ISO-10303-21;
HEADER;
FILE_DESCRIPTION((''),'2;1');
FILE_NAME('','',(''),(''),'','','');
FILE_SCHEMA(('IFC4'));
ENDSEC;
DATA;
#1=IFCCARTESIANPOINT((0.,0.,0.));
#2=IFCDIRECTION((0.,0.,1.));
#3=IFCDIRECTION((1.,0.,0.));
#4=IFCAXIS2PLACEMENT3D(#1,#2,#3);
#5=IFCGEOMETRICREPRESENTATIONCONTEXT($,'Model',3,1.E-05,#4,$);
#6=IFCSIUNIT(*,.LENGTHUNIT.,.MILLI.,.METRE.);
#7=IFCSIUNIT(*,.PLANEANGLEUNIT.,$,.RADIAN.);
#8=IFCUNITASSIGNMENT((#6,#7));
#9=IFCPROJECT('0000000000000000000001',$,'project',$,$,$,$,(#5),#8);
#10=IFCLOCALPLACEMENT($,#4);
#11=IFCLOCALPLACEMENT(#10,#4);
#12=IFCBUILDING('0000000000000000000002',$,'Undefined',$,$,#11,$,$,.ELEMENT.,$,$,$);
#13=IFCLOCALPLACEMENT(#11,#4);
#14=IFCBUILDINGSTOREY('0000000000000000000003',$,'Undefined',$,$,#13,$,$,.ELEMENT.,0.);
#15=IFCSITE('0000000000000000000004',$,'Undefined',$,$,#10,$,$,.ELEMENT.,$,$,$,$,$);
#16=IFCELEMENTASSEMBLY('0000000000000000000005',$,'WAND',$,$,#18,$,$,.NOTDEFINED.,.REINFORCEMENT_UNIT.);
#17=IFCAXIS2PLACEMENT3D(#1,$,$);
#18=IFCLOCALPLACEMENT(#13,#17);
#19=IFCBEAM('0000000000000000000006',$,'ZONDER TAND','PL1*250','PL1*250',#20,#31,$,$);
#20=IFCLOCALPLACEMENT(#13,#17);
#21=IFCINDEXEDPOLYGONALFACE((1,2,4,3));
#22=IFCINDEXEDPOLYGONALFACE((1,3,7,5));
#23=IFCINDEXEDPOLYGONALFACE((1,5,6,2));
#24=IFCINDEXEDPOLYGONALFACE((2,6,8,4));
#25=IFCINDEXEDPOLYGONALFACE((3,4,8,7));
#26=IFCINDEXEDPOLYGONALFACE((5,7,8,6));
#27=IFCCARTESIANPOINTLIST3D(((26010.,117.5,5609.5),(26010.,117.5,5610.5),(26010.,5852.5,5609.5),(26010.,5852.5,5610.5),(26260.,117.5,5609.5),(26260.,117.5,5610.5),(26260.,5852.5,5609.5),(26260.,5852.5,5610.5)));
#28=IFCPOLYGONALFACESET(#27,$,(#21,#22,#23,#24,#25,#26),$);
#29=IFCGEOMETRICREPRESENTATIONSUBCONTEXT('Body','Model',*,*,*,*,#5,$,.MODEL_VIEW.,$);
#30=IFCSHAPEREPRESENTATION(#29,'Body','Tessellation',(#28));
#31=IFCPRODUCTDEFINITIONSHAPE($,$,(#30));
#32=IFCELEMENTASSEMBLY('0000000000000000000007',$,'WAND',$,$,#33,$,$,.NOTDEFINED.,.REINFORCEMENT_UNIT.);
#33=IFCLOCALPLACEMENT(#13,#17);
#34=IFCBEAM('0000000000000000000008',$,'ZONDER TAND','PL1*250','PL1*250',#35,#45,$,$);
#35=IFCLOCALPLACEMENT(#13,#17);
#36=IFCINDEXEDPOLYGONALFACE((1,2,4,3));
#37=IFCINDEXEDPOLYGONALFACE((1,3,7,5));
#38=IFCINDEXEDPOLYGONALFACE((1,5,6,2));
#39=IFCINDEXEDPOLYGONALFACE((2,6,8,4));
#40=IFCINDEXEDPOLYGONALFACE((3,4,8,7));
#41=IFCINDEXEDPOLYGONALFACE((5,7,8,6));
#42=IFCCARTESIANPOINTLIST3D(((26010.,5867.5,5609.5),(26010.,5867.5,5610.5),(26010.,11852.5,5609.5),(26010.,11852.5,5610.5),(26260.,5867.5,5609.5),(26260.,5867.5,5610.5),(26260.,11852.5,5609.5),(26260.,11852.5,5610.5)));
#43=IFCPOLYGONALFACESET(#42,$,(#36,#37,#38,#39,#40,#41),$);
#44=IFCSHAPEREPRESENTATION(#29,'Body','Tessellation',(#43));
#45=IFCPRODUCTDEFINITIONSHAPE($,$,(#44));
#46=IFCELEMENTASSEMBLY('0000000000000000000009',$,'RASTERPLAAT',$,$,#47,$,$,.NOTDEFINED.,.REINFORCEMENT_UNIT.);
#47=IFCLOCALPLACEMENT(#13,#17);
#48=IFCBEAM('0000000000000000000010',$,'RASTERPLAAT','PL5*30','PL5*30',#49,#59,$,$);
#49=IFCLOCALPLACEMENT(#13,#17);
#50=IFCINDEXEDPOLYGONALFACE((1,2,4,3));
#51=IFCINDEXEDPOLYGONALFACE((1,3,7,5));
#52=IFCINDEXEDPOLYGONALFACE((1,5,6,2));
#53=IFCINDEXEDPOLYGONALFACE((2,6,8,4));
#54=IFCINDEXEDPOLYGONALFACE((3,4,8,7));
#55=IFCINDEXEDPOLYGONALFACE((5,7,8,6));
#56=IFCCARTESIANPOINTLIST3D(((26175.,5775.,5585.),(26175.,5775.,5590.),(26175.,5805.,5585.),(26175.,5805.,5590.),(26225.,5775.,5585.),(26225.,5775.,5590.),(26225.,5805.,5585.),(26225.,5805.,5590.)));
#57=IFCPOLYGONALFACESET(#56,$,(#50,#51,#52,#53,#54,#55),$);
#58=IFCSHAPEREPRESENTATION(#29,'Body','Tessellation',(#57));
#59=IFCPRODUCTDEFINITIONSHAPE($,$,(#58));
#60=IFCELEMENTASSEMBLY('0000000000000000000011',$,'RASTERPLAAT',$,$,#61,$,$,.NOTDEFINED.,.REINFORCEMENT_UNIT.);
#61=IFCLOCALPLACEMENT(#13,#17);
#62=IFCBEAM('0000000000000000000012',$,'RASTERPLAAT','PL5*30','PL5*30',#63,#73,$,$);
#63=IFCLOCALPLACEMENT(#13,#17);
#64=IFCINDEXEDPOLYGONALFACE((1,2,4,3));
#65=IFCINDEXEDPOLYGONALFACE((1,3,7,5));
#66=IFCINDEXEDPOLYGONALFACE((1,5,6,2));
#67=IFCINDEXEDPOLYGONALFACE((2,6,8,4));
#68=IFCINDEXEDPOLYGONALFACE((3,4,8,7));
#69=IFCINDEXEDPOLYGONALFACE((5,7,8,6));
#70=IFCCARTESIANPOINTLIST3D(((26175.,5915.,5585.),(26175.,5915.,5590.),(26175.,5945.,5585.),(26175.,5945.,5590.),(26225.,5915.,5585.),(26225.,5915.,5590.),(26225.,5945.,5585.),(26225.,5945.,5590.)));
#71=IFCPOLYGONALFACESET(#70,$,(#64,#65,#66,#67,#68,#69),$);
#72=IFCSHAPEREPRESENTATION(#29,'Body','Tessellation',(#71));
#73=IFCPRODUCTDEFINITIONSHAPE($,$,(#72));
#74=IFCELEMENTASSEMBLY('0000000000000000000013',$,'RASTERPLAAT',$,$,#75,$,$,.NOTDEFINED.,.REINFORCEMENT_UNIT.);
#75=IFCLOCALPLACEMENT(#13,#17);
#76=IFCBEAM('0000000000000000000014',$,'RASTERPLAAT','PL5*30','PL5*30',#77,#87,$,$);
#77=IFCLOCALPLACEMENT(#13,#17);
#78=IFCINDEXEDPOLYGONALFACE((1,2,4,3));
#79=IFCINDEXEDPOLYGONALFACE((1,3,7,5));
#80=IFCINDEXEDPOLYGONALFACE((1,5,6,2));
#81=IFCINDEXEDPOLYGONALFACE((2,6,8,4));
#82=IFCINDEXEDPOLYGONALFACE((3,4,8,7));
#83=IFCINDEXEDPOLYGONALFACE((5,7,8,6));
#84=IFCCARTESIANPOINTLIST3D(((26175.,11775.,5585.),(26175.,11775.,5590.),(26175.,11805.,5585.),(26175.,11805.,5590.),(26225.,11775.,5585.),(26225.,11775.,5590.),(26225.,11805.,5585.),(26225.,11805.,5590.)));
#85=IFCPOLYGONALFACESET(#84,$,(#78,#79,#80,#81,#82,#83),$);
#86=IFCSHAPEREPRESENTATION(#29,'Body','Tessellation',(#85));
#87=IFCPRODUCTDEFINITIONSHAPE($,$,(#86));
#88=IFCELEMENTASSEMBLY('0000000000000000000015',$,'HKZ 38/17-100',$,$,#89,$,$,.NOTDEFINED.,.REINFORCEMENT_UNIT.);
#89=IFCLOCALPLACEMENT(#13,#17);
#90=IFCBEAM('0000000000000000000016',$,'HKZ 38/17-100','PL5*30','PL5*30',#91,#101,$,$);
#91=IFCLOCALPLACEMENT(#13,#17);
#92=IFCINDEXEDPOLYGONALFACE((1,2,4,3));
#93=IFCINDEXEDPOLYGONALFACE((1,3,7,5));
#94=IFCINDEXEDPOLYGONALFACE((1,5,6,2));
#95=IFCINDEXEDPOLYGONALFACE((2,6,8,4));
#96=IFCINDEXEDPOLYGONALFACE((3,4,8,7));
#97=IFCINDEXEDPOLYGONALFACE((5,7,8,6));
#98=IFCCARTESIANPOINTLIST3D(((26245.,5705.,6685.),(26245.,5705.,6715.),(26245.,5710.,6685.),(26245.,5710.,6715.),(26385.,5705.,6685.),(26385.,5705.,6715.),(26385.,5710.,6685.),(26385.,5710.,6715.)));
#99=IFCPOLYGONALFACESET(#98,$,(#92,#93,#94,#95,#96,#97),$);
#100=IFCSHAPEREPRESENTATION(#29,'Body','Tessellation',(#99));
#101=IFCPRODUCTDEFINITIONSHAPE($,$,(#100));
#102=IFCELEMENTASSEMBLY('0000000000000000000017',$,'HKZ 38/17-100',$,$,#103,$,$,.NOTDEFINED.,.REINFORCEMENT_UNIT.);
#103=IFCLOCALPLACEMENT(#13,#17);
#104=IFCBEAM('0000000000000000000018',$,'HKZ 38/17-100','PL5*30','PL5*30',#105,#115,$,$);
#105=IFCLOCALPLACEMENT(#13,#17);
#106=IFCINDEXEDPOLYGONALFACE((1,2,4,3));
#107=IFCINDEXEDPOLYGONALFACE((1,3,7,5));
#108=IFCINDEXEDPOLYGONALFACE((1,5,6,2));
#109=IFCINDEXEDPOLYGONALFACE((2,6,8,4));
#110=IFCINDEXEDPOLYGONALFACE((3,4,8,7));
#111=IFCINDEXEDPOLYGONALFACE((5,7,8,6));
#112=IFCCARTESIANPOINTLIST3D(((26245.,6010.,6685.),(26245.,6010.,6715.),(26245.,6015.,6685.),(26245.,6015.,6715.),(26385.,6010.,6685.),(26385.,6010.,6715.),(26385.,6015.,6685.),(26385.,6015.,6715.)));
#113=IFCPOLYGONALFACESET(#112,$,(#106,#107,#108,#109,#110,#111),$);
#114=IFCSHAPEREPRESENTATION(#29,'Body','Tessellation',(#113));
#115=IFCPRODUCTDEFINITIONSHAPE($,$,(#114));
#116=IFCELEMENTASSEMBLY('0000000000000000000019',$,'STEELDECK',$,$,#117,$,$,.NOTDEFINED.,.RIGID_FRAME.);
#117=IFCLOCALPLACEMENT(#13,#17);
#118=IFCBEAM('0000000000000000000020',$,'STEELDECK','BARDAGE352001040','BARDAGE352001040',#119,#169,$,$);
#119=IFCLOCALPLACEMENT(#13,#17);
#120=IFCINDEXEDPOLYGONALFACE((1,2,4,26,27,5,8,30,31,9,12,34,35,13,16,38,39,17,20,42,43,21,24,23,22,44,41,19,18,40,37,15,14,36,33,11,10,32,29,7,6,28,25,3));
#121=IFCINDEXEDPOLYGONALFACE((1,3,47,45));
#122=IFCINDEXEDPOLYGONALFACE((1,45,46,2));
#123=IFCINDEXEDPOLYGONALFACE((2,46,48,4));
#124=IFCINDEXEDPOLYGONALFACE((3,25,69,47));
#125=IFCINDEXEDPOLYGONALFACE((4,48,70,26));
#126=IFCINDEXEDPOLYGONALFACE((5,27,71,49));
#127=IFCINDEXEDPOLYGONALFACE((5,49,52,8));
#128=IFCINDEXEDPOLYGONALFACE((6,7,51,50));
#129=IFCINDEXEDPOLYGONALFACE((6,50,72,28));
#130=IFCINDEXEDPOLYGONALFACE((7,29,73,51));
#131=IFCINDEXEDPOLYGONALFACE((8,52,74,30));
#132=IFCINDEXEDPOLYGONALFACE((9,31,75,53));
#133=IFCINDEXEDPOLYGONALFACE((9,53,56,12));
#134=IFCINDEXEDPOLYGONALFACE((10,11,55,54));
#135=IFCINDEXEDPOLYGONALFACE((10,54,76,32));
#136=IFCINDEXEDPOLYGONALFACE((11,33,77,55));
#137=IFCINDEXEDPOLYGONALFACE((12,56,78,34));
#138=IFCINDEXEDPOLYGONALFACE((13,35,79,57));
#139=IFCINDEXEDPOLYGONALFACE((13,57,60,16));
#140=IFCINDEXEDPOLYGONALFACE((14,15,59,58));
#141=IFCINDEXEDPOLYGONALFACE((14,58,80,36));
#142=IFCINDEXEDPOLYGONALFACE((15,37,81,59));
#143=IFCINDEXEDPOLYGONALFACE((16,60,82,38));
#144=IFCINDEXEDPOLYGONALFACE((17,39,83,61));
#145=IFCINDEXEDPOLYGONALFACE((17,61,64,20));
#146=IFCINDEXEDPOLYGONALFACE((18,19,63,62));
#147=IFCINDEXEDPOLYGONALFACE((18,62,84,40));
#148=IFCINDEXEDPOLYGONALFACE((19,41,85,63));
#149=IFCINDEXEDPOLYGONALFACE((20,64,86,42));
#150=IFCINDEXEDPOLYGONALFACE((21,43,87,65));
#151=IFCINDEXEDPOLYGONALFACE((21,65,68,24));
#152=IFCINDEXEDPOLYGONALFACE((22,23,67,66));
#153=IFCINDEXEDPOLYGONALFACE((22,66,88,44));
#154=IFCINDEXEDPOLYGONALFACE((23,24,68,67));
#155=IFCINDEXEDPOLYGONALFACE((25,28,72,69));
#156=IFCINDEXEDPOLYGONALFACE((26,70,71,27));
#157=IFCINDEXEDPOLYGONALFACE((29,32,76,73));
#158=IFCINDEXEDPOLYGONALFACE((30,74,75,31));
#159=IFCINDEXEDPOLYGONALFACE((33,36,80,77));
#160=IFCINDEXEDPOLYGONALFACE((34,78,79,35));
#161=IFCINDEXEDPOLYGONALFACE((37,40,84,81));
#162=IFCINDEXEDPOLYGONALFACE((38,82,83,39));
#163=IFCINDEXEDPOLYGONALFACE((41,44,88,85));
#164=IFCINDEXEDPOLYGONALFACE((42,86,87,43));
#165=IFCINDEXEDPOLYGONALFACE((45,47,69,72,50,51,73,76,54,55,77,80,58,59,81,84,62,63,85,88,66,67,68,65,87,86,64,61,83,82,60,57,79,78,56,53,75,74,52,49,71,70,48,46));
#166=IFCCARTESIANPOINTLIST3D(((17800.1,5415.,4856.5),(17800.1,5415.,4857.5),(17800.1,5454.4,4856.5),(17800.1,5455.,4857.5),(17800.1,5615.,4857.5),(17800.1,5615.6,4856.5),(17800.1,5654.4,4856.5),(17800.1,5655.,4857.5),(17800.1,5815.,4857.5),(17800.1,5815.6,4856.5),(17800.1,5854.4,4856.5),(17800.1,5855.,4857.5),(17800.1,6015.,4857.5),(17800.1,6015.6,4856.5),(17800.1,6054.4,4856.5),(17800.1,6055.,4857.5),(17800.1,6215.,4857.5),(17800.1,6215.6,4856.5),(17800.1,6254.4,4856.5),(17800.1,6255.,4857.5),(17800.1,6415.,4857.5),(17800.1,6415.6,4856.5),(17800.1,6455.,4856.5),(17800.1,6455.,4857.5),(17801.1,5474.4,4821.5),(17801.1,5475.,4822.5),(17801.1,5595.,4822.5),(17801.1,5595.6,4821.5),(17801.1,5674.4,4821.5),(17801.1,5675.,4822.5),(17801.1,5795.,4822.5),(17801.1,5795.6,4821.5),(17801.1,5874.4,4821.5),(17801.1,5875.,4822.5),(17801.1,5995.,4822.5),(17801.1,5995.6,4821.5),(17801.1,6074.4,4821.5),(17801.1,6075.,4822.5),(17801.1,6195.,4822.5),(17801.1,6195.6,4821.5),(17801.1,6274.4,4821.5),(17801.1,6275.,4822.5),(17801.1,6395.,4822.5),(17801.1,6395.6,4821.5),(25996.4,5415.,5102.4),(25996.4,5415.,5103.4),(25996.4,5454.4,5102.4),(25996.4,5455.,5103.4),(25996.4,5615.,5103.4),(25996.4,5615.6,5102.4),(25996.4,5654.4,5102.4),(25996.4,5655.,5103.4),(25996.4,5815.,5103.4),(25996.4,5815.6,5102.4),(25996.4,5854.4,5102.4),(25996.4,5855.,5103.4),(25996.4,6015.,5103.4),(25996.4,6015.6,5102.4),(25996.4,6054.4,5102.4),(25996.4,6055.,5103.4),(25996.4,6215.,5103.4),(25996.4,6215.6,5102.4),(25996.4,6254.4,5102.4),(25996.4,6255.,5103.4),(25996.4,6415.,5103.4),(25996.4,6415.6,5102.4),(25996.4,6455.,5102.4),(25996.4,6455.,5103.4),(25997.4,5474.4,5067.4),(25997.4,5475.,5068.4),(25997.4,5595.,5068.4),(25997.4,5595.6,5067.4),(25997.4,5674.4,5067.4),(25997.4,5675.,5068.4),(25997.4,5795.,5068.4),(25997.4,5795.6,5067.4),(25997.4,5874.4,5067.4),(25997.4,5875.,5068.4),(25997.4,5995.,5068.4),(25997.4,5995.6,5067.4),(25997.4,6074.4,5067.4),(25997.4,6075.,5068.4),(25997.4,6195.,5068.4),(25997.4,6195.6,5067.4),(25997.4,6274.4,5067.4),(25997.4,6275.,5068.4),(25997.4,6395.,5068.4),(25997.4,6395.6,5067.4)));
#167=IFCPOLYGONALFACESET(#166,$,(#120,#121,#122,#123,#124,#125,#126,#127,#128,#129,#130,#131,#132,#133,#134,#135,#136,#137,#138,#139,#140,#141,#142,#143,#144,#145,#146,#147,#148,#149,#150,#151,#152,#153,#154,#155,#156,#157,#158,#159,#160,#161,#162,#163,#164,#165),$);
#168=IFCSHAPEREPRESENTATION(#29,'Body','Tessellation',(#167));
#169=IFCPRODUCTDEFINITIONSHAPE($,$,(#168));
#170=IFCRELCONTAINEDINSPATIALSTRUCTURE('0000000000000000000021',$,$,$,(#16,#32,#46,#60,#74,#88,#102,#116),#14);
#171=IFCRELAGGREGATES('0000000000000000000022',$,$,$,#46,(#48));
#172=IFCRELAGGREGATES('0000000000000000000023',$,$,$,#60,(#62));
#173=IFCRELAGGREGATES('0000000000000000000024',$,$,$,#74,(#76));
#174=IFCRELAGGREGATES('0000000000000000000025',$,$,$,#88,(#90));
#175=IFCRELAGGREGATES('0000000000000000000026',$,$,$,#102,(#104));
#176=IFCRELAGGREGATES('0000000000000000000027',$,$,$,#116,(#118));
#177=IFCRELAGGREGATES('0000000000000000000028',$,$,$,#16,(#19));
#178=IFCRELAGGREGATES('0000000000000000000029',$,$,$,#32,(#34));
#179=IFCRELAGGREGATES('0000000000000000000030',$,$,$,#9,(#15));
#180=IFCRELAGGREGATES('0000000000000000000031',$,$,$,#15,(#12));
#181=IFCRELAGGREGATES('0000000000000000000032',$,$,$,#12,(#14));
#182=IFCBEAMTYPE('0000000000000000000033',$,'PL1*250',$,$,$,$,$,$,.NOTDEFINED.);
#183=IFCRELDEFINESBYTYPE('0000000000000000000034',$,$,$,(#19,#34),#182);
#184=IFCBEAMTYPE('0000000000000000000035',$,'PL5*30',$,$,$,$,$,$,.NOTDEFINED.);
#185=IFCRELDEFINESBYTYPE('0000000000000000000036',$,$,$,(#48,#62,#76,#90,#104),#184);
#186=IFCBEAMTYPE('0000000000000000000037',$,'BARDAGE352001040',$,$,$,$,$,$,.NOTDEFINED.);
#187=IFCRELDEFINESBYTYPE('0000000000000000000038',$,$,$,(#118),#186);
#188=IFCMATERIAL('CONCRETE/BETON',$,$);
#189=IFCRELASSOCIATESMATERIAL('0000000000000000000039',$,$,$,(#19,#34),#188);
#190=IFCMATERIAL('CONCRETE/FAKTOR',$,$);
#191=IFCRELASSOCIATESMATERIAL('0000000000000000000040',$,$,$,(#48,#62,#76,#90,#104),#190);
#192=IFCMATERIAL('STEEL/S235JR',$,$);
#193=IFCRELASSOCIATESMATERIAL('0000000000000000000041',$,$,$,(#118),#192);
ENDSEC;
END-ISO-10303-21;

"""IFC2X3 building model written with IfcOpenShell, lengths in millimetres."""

from ifc_helpers import new_model, si_unit, frame, frame_2d, origin_with_axes, place, context, subcontext, project, spatial, polyline, rectangle, outline, extrude, material, type_object, element, aggregate, save


model = new_model("IFC2X3")

# Units and contexts
model_context = context("Model", 3, precision=1e-05, world=origin_with_axes())
body_context = subcontext(model_context, "Body", "Model", "MODEL_VIEW")
ifc_project = project(units=[si_unit("LENGTHUNIT", "METRE", prefix="MILLI"), si_unit("PLANEANGLEUNIT", "RADIAN")], contexts=[model_context])

# Site, building, storey
site_placement = place(None, origin_with_axes())
site = spatial("IfcSite", under=ifc_project, at=site_placement, Name="Undefined", CompositionType="ELEMENT")
building_placement = place(site_placement, origin_with_axes())
building = spatial("IfcBuilding", under=site, at=building_placement, Name="Undefined", CompositionType="ELEMENT")
storey_placement = place(building_placement, origin_with_axes())
storey = spatial("IfcBuildingStorey", under=building, at=storey_placement, Name="Undefined", CompositionType="ELEMENT", Elevation=0.0)

# Element assemblies, beams
assembly_1_placement = place(storey_placement, origin_with_axes())
assembly_1 = element("IfcElementAssembly", 1, at=assembly_1_placement, inside=storey, Name="WAND", AssemblyPlace="NOTDEFINED", PredefinedType="REINFORCEMENT_UNIT")
ifc_material_1 = material(Name="CONCRETE/BETON")
beam_type_1 = type_object("IfcBeamType", Name="PL1*250", PredefinedType="NOTDEFINED")
beam_1_placement = place(assembly_1_placement, frame((26135.0, 5852.5, 5610.0), z_axis=(-1.0, 0.0, 0.0), x_axis=(0.0, -1.0, 0.0)))
beam_1 = element("IfcBeam", 2, at=beam_1_placement, type_object=beam_type_1, material=ifc_material_1, Name="ZONDER TAND", Description="PL1*250", ObjectType="PL1*250", context=body_context, shape_type="SweptSolid", body=[
    extrude(rectangle(XDim=1.0, YDim=250.0, at=frame_2d((0.0, 0.0), x_axis=(1.0, 0.0))), frame((5735.0, 0.0, 0.0), z_axis=(-1.0, 0.0, 0.0), x_axis=(0.0, -1.0, 0.0)), (0.0, 0.0, 1.0), 5735.0),
])
assembly_2_placement = place(storey_placement, origin_with_axes())
assembly_2 = element("IfcElementAssembly", 3, at=assembly_2_placement, inside=storey, Name="WAND", AssemblyPlace="NOTDEFINED", PredefinedType="REINFORCEMENT_UNIT")
beam_2_placement = place(assembly_2_placement, frame((26135.0, 11852.5, 5610.0), z_axis=(-1.0, 0.0, 0.0), x_axis=(0.0, -1.0, 0.0)))
beam_2 = element("IfcBeam", 4, at=beam_2_placement, type_object=beam_type_1, material=ifc_material_1, Name="ZONDER TAND", Description="PL1*250", ObjectType="PL1*250", context=body_context, shape_type="SweptSolid", body=[
    extrude(rectangle(XDim=1.0, YDim=250.0, at=frame_2d((0.0, 0.0), x_axis=(1.0, 0.0))), frame((5985.0, 0.0, 0.0), z_axis=(-1.0, 0.0, 0.0), x_axis=(0.0, -1.0, 0.0)), (0.0, 0.0, 1.0), 5985.0),
])
assembly_3_placement = place(storey_placement, origin_with_axes())
assembly_3 = element("IfcElementAssembly", 5, at=assembly_3_placement, inside=storey, Name="RASTERPLAAT", AssemblyPlace="NOTDEFINED", PredefinedType="REINFORCEMENT_UNIT")
ifc_material_2 = material(Name="CONCRETE/FAKTOR")
beam_type_2 = type_object("IfcBeamType", Name="PL5*30", PredefinedType="NOTDEFINED")
beam_3_placement = place(assembly_3_placement, frame((26225.0, 5790.0, 5587.5), z_axis=(0.0, 1.0, 0.0), x_axis=(-1.0, 0.0, 0.0)))
beam_3 = element("IfcBeam", 6, at=beam_3_placement, type_object=beam_type_2, material=ifc_material_2, Name="RASTERPLAAT", Description="PL5*30", ObjectType="PL5*30", context=body_context, shape_type="SweptSolid", body=[
    extrude(rectangle(XDim=5.0, YDim=30.0, at=frame_2d((0.0, 0.0), x_axis=(1.0, 0.0))), frame((50.0, 0.0, 0.0), z_axis=(-1.0, 0.0, 0.0), x_axis=(0.0, -1.0, 0.0)), (0.0, 0.0, 1.0), 50.0),
])
aggregate(assembly_3, [beam_3])
assembly_4_placement = place(storey_placement, origin_with_axes())
assembly_4 = element("IfcElementAssembly", 7, at=assembly_4_placement, inside=storey, Name="RASTERPLAAT", AssemblyPlace="NOTDEFINED", PredefinedType="REINFORCEMENT_UNIT")
beam_4_placement = place(assembly_4_placement, frame((26225.0, 5930.0, 5587.5), z_axis=(0.0, -1.0, 0.0), x_axis=(-1.0, 0.0, 0.0)))
beam_4 = element("IfcBeam", 8, at=beam_4_placement, type_object=beam_type_2, material=ifc_material_2, Name="RASTERPLAAT", Description="PL5*30", ObjectType="PL5*30", context=body_context, shape_type="SweptSolid", body=[
    extrude(rectangle(XDim=5.0, YDim=30.0, at=frame_2d((0.0, 0.0), x_axis=(1.0, 0.0))), frame((50.0, 0.0, 0.0), z_axis=(-1.0, 0.0, 0.0), x_axis=(0.0, -1.0, 0.0)), (0.0, 0.0, 1.0), 50.0),
])
aggregate(assembly_4, [beam_4])
assembly_5_placement = place(storey_placement, origin_with_axes())
assembly_5 = element("IfcElementAssembly", 9, at=assembly_5_placement, inside=storey, Name="RASTERPLAAT", AssemblyPlace="NOTDEFINED", PredefinedType="REINFORCEMENT_UNIT")
beam_5_placement = place(assembly_5_placement, frame((26225.0, 11790.0, 5587.5), z_axis=(0.0, 1.0, 0.0), x_axis=(-1.0, 0.0, 0.0)))
beam_5 = element("IfcBeam", 10, at=beam_5_placement, type_object=beam_type_2, material=ifc_material_2, Name="RASTERPLAAT", Description="PL5*30", ObjectType="PL5*30", context=body_context, shape_type="SweptSolid", body=[
    extrude(rectangle(XDim=5.0, YDim=30.0, at=frame_2d((0.0, 0.0), x_axis=(1.0, 0.0))), frame((50.0, 0.0, 0.0), z_axis=(-1.0, 0.0, 0.0), x_axis=(0.0, -1.0, 0.0)), (0.0, 0.0, 1.0), 50.0),
])
aggregate(assembly_5, [beam_5])
assembly_6_placement = place(storey_placement, origin_with_axes())
assembly_6 = element("IfcElementAssembly", 11, at=assembly_6_placement, inside=storey, Name="HKZ 38/17-100", AssemblyPlace="NOTDEFINED", PredefinedType="REINFORCEMENT_UNIT")
beam_6_placement = place(assembly_6_placement, frame((26245.0, 5707.5, 6700.0), z_axis=(0.0, 0.0, 1.0), x_axis=(1.0, 0.0, 0.0)))
beam_6 = element("IfcBeam", 12, at=beam_6_placement, type_object=beam_type_2, material=ifc_material_2, Name="HKZ 38/17-100", Description="PL5*30", ObjectType="PL5*30", context=body_context, shape_type="SweptSolid", body=[
    extrude(rectangle(XDim=5.0, YDim=30.0, at=frame_2d((0.0, 0.0), x_axis=(1.0, 0.0))), frame((140.0, 0.0, 0.0), z_axis=(-1.0, 0.0, 0.0), x_axis=(0.0, -1.0, 0.0)), (0.0, 0.0, 1.0), 140.0),
])
aggregate(assembly_6, [beam_6])
assembly_7_placement = place(storey_placement, origin_with_axes())
assembly_7 = element("IfcElementAssembly", 13, at=assembly_7_placement, inside=storey, Name="HKZ 38/17-100", AssemblyPlace="NOTDEFINED", PredefinedType="REINFORCEMENT_UNIT")
beam_7_placement = place(assembly_7_placement, frame((26245.0, 6012.5, 6700.0), z_axis=(0.0, 0.0, -1.0), x_axis=(1.0, 0.0, 0.0)))
beam_7 = element("IfcBeam", 14, at=beam_7_placement, type_object=beam_type_2, material=ifc_material_2, Name="HKZ 38/17-100", Description="PL5*30", ObjectType="PL5*30", context=body_context, shape_type="SweptSolid", body=[
    extrude(rectangle(XDim=5.0, YDim=30.0, at=frame_2d((0.0, 0.0), x_axis=(1.0, 0.0))), frame((140.0, 0.0, 0.0), z_axis=(-1.0, 0.0, 0.0), x_axis=(0.0, -1.0, 0.0)), (0.0, 0.0, 1.0), 140.0),
])
aggregate(assembly_7, [beam_7])
assembly_8_placement = place(storey_placement, origin_with_axes())
assembly_8 = element("IfcElementAssembly", 15, at=assembly_8_placement, inside=storey, Name="STEELDECK", AssemblyPlace="NOTDEFINED", PredefinedType="RIGID_FRAME")
ifc_material_3 = material(Name="STEEL/S235JR")
beam_type_3 = type_object("IfcBeamType", Name="BARDAGE352001040", PredefinedType="NOTDEFINED")
beam_8_placement = place(assembly_8_placement, frame((17800.1, 6455.0, 4857.5), z_axis=(-0.029987, 0.0, 0.99955), x_axis=(0.99955, 0.0, 0.029986)))
beam_8 = element("IfcBeam", 16, at=beam_8_placement, type_object=beam_type_3, material=ifc_material_3, Name="STEELDECK", Description="BARDAGE352001040", ObjectType="BARDAGE352001040", context=body_context, shape_type="SweptSolid", body=[
    extrude(outline(polyline([(200.6, -1.0), (180.6, -36.0), (59.4, -36.0), (39.4, -1.0), (0.0, -1.0), (0.0, 0.0), (40.0, 0.0), (60.0, -35.0), (180.0, -35.0), (200.0, 0.0), (240.0, 0.0), (260.0, -35.0), (380.0, -35.0), (400.0, 0.0), (440.0, 0.0), (460.0, -35.0), (580.0, -35.0), (600.0, 0.0), (640.0, 0.0), (660.0, -35.0), (780.0, -35.0), (800.0, 0.0), (840.0, 0.0), (860.0, -35.0), (980.0, -35.0), (1000.0, 0.0), (1040.0, 0.0), (1040.0, -1.0), (1000.6, -1.0), (980.6, -36.0), (859.4, -36.0), (839.4, -1.0), (800.6, -1.0), (780.6, -36.0), (659.4, -36.0), (639.4, -1.0), (600.6, -1.0), (580.6, -36.0), (459.4, -36.0), (439.4, -1.0), (400.6, -1.0), (380.6, -36.0), (259.4, -36.0), (239.4, -1.0), (200.6, -1.0)])), frame((8200.0, 0.0, 0.0), z_axis=(-1.0, 0.0, 0.0), x_axis=(0.0, -1.0, 0.0)), (0.0, 0.0, 1.0), 8200.0),
])
aggregate(assembly_8, [beam_8])

aggregate(assembly_1, [beam_1])
aggregate(assembly_2, [beam_2])

save(model, "model.ifc")
